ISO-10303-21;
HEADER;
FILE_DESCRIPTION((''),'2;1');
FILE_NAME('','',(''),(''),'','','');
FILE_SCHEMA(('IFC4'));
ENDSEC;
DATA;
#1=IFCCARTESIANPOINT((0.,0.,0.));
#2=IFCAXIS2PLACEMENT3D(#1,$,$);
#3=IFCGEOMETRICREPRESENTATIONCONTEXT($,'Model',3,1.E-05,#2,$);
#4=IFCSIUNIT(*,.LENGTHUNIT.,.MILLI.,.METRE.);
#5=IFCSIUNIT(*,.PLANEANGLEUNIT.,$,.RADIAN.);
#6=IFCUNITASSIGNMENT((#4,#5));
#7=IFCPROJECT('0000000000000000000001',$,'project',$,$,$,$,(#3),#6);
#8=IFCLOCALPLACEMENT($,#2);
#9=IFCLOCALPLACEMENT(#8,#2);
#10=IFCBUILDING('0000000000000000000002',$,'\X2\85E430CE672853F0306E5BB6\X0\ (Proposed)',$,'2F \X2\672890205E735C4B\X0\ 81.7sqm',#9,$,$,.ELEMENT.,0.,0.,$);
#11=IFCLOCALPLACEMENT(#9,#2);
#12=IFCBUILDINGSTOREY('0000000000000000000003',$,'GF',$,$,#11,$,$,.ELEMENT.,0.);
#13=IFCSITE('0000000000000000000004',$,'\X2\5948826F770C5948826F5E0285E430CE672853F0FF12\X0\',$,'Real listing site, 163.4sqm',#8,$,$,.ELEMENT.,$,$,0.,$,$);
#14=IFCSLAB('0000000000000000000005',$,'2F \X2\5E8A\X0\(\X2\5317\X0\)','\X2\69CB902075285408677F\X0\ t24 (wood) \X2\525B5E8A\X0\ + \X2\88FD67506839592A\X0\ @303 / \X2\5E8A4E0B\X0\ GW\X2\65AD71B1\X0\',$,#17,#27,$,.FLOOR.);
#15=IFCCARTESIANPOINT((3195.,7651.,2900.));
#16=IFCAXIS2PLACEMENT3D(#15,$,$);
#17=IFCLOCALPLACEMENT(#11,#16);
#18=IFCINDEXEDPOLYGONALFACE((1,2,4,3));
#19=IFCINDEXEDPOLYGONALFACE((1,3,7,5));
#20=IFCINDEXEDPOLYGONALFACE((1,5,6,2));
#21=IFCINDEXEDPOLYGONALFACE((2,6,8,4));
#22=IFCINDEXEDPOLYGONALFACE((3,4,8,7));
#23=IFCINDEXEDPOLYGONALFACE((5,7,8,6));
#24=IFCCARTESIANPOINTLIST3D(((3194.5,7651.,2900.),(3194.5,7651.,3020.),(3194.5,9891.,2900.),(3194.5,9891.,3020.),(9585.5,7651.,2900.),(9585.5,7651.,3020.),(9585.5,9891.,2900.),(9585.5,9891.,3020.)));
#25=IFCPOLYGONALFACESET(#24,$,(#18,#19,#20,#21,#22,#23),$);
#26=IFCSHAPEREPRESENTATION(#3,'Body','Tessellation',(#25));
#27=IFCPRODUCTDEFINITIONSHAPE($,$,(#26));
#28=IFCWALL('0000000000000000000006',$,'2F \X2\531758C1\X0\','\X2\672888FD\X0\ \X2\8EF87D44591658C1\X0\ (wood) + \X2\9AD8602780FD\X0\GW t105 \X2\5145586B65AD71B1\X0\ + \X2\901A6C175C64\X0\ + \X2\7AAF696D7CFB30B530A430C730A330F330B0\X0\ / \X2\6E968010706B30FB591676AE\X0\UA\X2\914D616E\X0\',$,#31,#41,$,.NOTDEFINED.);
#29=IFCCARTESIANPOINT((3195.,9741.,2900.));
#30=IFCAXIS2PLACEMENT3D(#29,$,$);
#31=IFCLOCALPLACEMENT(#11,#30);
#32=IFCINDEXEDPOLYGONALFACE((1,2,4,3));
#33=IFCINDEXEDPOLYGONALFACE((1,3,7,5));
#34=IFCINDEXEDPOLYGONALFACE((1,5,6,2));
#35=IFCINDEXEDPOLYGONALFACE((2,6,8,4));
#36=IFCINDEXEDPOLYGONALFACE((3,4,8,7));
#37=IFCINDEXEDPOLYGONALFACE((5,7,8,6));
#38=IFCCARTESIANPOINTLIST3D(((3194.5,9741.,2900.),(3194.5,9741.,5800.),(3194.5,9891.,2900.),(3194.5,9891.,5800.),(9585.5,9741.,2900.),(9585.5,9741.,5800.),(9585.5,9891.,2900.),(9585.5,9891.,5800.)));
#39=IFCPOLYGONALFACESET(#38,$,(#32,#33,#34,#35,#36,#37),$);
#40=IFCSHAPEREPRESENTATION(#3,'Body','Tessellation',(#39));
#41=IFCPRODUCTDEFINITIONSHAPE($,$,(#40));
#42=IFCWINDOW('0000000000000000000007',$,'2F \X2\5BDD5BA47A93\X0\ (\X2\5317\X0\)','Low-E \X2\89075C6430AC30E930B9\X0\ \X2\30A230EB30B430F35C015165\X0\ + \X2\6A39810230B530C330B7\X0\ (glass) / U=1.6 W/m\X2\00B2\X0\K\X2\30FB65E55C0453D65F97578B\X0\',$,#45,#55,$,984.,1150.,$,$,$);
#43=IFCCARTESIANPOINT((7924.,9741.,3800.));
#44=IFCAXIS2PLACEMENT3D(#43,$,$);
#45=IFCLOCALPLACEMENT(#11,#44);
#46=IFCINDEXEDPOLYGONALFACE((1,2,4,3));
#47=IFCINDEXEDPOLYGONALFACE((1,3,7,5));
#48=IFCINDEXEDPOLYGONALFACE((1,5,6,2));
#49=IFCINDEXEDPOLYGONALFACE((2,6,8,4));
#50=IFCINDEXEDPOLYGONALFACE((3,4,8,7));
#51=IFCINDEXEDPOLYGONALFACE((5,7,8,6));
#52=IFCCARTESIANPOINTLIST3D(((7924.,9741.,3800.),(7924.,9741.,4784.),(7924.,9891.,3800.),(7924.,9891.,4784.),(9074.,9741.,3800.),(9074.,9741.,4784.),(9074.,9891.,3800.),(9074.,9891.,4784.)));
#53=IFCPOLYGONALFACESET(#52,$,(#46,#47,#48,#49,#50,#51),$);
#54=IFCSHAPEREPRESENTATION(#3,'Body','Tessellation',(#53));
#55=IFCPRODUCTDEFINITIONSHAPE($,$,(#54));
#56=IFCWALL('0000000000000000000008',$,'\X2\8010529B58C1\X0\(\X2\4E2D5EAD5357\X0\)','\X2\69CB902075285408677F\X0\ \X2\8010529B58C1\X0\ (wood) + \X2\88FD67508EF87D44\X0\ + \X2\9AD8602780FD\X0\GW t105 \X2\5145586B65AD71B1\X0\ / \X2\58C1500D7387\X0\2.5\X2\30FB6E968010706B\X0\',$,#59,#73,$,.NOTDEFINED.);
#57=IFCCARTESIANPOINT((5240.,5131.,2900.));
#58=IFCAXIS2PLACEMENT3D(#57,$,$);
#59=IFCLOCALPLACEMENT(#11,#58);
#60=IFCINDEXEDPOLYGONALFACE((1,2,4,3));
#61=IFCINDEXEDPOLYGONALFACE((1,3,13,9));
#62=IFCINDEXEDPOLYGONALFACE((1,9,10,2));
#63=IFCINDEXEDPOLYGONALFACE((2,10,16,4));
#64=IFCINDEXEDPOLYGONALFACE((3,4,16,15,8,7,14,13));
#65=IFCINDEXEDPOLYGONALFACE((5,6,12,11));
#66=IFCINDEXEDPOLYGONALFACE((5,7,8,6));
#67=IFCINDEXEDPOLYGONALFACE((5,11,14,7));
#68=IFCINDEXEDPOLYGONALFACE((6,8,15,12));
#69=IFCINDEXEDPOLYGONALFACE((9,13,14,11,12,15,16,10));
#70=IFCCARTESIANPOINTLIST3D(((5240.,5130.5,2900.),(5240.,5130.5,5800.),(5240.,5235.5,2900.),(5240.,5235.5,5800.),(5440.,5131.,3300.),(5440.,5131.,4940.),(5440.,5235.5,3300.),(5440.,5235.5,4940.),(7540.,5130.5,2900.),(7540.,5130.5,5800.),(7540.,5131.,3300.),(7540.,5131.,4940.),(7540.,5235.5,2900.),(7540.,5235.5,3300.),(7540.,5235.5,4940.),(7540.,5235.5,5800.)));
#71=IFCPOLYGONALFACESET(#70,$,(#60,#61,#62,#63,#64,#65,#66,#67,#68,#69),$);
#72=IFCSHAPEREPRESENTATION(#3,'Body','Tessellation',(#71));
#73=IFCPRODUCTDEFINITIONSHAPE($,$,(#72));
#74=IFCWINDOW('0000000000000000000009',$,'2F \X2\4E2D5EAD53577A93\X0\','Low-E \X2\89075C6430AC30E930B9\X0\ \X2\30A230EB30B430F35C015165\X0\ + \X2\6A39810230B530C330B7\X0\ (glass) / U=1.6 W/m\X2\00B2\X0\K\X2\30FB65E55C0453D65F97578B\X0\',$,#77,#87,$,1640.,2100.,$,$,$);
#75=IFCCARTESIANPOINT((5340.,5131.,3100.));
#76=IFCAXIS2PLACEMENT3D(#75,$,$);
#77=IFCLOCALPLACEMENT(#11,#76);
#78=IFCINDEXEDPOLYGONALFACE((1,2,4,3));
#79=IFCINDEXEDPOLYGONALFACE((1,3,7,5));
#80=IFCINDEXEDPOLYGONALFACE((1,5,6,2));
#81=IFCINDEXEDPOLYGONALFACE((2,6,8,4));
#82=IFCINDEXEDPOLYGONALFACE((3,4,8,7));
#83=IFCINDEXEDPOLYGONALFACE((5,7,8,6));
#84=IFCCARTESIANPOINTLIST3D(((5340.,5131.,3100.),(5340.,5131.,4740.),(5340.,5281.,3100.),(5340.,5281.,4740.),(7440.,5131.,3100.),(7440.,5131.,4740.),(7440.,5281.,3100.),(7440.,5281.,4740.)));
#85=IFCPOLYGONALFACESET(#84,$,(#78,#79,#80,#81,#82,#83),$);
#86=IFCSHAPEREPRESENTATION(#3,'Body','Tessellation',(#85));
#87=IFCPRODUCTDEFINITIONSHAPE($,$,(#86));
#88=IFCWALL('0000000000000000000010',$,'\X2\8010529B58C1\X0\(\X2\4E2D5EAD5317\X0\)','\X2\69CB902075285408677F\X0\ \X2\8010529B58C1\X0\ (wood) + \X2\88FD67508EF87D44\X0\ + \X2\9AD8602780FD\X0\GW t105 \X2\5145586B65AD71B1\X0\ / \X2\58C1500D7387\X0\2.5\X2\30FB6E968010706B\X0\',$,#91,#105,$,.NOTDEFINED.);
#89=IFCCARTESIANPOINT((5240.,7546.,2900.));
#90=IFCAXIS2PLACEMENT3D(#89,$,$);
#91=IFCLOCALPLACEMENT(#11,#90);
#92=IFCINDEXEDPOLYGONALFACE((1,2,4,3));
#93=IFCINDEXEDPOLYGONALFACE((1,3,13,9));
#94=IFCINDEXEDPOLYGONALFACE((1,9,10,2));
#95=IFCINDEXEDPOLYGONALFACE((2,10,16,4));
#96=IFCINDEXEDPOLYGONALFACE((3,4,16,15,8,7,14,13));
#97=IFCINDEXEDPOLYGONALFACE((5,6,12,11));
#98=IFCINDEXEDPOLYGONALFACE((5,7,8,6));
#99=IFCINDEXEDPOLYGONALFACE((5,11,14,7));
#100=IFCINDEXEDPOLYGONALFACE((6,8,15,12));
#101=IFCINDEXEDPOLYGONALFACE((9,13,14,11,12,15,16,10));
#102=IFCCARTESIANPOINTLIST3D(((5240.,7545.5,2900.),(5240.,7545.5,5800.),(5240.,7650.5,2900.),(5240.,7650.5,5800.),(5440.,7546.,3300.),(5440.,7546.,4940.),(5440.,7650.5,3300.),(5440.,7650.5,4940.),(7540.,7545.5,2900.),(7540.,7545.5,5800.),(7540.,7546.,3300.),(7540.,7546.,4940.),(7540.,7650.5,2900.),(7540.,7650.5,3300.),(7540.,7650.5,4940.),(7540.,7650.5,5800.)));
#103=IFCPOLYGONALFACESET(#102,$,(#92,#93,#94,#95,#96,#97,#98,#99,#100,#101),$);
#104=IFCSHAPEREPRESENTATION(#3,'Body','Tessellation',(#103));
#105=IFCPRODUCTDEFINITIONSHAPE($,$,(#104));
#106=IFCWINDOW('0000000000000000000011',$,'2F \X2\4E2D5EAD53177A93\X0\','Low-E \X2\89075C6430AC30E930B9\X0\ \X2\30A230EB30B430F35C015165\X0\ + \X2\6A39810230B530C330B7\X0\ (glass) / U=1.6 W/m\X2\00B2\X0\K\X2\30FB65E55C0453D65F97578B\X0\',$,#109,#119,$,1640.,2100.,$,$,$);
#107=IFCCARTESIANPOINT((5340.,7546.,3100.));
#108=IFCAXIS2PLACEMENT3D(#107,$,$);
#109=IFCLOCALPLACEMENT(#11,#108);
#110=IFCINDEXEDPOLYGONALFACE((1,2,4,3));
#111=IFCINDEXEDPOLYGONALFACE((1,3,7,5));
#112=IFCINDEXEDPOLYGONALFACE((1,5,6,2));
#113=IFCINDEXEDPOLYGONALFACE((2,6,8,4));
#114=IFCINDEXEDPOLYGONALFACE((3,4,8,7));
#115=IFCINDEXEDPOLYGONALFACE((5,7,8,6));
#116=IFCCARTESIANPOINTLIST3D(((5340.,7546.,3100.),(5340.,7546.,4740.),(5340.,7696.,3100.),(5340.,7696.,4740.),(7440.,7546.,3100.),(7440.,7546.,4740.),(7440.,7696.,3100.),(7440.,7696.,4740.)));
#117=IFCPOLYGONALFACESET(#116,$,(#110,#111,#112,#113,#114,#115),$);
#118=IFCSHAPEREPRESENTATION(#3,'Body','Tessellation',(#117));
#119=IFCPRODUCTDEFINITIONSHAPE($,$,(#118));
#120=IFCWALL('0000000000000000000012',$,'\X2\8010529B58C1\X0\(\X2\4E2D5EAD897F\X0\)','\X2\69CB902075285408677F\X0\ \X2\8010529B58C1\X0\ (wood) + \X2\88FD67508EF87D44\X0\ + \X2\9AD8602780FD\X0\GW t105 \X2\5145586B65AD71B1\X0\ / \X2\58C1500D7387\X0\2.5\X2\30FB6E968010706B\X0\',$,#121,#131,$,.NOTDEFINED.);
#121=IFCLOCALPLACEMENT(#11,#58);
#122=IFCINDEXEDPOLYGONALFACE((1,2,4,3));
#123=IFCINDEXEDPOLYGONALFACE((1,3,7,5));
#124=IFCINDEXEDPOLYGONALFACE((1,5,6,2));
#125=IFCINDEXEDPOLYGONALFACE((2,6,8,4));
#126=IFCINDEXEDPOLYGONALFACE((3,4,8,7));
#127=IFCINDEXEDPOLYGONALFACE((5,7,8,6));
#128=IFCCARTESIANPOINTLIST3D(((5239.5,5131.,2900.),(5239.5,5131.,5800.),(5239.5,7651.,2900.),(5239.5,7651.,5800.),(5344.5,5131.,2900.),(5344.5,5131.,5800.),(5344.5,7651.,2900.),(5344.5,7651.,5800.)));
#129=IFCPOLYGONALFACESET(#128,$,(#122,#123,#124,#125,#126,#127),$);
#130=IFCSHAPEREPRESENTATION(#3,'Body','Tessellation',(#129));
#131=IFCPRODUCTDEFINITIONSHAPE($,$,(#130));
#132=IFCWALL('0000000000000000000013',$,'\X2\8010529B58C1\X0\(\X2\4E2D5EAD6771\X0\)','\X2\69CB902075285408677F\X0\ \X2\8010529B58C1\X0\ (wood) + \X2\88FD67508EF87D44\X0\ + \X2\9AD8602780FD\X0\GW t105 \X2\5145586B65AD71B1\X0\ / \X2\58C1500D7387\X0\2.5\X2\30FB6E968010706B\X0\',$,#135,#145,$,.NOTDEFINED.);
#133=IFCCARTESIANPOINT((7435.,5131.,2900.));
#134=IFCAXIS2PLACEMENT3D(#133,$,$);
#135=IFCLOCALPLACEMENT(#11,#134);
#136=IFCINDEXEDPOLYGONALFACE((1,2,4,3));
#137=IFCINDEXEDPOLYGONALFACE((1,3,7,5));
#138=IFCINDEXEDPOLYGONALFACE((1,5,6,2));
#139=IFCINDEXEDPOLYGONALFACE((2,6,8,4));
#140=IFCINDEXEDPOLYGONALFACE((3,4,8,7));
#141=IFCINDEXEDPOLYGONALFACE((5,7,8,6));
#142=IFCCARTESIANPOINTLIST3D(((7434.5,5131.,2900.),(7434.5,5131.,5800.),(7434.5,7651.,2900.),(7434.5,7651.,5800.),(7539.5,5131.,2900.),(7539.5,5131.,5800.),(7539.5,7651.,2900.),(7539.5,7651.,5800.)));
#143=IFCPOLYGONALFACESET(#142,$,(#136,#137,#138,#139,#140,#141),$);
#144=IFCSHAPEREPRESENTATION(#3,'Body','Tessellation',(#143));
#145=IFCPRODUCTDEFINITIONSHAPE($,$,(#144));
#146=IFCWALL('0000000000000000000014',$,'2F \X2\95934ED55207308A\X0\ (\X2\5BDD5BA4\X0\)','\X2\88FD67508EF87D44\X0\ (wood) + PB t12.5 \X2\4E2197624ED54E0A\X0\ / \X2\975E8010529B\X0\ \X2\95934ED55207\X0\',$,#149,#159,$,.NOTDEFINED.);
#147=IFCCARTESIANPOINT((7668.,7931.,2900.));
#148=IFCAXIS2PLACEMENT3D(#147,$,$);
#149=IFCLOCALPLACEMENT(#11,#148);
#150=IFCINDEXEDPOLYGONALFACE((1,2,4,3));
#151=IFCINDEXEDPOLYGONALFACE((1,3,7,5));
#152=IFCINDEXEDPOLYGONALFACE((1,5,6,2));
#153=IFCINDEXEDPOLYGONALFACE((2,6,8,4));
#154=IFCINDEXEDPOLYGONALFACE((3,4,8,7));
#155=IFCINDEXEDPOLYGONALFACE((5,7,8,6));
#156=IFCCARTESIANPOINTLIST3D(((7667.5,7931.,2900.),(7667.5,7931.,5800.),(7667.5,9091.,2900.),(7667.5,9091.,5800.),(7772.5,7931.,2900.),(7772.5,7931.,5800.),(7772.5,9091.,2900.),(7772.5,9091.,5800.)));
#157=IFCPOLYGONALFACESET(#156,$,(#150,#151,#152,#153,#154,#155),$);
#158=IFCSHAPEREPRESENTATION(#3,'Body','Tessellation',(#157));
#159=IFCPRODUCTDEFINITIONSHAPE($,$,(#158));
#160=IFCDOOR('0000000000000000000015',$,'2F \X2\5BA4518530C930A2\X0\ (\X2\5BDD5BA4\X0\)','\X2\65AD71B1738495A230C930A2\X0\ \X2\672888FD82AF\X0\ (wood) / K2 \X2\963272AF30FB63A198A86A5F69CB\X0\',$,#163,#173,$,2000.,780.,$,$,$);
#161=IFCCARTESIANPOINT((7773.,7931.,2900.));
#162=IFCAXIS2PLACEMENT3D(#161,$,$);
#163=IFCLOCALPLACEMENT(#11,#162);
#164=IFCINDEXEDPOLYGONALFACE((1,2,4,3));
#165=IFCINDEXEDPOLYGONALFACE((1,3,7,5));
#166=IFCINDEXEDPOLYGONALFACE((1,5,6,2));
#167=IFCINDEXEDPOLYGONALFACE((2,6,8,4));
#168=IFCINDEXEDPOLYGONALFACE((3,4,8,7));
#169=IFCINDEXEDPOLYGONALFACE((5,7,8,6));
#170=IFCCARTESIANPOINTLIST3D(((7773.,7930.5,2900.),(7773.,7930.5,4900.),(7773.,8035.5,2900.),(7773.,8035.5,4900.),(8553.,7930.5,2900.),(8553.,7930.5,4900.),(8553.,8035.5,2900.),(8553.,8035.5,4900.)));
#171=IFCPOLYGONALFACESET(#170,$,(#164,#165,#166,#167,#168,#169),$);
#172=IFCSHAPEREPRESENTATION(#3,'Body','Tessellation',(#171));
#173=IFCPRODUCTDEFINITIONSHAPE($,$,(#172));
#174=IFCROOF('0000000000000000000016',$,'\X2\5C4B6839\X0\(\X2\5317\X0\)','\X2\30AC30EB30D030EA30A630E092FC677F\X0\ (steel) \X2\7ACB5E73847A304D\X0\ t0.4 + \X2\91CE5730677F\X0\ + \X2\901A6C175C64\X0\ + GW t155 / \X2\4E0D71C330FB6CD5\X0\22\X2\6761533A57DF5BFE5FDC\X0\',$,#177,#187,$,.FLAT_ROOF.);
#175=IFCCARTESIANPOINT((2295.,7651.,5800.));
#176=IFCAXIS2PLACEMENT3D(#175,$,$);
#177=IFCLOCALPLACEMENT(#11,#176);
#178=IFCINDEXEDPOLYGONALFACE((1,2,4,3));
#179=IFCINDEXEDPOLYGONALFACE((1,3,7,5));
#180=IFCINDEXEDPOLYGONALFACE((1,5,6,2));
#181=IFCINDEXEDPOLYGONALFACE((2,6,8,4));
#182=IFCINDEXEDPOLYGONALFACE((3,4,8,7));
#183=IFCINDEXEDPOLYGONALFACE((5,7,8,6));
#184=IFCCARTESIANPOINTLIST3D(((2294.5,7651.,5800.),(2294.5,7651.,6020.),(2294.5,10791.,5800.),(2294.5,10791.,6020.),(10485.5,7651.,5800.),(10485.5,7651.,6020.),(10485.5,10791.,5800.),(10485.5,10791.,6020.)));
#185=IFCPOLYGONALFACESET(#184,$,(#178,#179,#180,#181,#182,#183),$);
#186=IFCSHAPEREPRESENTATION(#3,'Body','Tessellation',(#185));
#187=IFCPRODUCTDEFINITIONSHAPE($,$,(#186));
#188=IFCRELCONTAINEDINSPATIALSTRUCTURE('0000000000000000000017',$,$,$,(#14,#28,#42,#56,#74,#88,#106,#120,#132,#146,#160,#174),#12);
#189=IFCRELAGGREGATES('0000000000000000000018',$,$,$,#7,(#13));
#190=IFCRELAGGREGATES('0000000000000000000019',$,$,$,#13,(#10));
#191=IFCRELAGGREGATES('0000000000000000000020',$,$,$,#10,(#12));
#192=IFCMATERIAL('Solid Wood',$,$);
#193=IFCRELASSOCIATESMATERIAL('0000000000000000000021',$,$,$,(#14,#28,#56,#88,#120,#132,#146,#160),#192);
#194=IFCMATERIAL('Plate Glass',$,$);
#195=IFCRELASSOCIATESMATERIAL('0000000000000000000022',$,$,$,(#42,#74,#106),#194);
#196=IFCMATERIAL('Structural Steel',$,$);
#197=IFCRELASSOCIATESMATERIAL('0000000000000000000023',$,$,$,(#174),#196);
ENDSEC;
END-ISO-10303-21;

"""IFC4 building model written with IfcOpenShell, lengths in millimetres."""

from ifc_helpers import new_model, si_unit, frame, frame_2d, origin, place, context, project, spatial, rectangle, extrude, material, element, fill, save


model = new_model("IFC4")

# Units and contexts
model_context = context("Model", 3, precision=1e-05, world=origin())
ifc_project = project(units=[si_unit("LENGTHUNIT", "METRE", prefix="MILLI"), si_unit("PLANEANGLEUNIT", "RADIAN")], contexts=[model_context])

# Site, building, storey
site_placement = place(None, origin())
site = spatial("IfcSite", under=ifc_project, at=site_placement, Name="奈良県奈良市藤ノ木台２", ObjectType="Real listing site, 163.4sqm", CompositionType="ELEMENT", RefElevation=0.0)
building_placement = place(site_placement, origin())
building = spatial("IfcBuilding", under=site, at=building_placement, Name="藤ノ木台の家 (Proposed)", ObjectType="2F 木造平屋 81.7sqm", CompositionType="ELEMENT", ElevationOfRefHeight=0.0, ElevationOfTerrain=0.0)
storey_placement = place(building_placement, origin())
storey = spatial("IfcBuildingStorey", under=building, at=storey_placement, Name="GF", CompositionType="ELEMENT", Elevation=0.0)

# Slab
ifc_material_1 = material(Name="Solid Wood")
slab_placement = place(storey_placement, frame((3195.0, 7651.0, 2900.0)))
element("IfcSlab", 1, at=slab_placement, inside=storey, material=ifc_material_1, Name="2F 床(北)", Description="構造用合板 t24 (wood) 剛床 + 製材根太 @303 / 床下 GW断熱", PredefinedType="FLOOR", context=model_context, shape_type="SweptSolid", body=[
    extrude(rectangle(XDim=6391.0, YDim=2240.0, at=frame_2d((3195.0, 1120.0))), frame((3195.0, 7651.0, 2900.0)), (0.0, 0.0, 1.0), 120.0),
])

# Walls, openings, windows
wall_1_placement = place(storey_placement, frame((3195.0, 9741.0, 2900.0)))
wall_1 = element("IfcWall", 2, at=wall_1_placement, inside=storey, material=ifc_material_1, Name="2F 北壁", Description="木製 軸組外壁 (wood) + 高性能GW t105 充填断熱 + 通気層 + 窯業系サイディング / 準耐火・外皮UA配慮", PredefinedType="NOTDEFINED", context=model_context, shape_type="SweptSolid", body=[
    extrude(rectangle(XDim=6391.0, YDim=150.0, at=frame_2d((3195.0, 75.0))), frame((3195.0, 9741.0, 2900.0)), (0.0, 0.0, 1.0), 2900.0),
])
opening_1_placement = place(storey_placement, frame((7924.0, 9741.0, 3800.0)))
opening_1 = element("IfcOpeningElement", 3, at=opening_1_placement, cuts=wall_1, PredefinedType="NOTDEFINED", context=model_context, shape_type="SweptSolid", body=[
    extrude(rectangle(XDim=1150.0, YDim=150.0, at=frame_2d((575.0, 75.0))), frame((7924.0, 9741.0, 3800.0)), (0.0, 0.0, 1.0), 984.0),
])
ifc_material_2 = material(Name="Plate Glass")
window_1_placement = place(storey_placement, frame((7924.0, 9741.0, 3800.0)))
window_1 = element("IfcWindow", 4, at=window_1_placement, inside=storey, material=ifc_material_2, Name="2F 寝室窓 (北)", Description="Low-E 複層ガラス アルゴン封入 + 樹脂サッシ (glass) / U=1.6 W/m²K・日射取得型", OverallHeight=984.0, OverallWidth=1150.0, context=model_context, shape_type="SweptSolid", body=[
    extrude(rectangle(XDim=1150.0, YDim=150.0, at=frame_2d((575.0, 75.0))), frame((7924.0, 9741.0, 3800.0)), (0.0, 0.0, 1.0), 984.0),
])
fill(opening_1, window_1)
wall_2_placement = place(storey_placement, frame((5240.0, 5131.0, 2900.0)))
wall_2 = element("IfcWall", 5, at=wall_2_placement, inside=storey, material=ifc_material_1, Name="耐力壁(中庭南)", Description="構造用合板 耐力壁 (wood) + 製材軸組 + 高性能GW t105 充填断熱 / 壁倍率2.5・準耐火", PredefinedType="NOTDEFINED", context=model_context, shape_type="SweptSolid", body=[
    extrude(rectangle(XDim=2300.0, YDim=105.0, at=frame_2d((1150.0, 52.0))), frame((5240.0, 5131.0, 2900.0)), (0.0, 0.0, 1.0), 2900.0),
])
opening_2_placement = place(storey_placement, frame((5340.0, 5131.0, 3100.0)))
opening_2 = element("IfcOpeningElement", 6, at=opening_2_placement, cuts=wall_2, PredefinedType="NOTDEFINED", context=model_context, shape_type="SweptSolid", body=[
    extrude(rectangle(XDim=2100.0, YDim=150.0, at=frame_2d((1050.0, 75.0))), frame((5340.0, 5131.0, 3100.0)), (0.0, 0.0, 1.0), 1640.0),
])
window_2_placement = place(storey_placement, frame((5340.0, 5131.0, 3100.0)))
window_2 = element("IfcWindow", 7, at=window_2_placement, inside=storey, material=ifc_material_2, Name="2F 中庭南窓", Description="Low-E 複層ガラス アルゴン封入 + 樹脂サッシ (glass) / U=1.6 W/m²K・日射取得型", OverallHeight=1640.0, OverallWidth=2100.0, context=model_context, shape_type="SweptSolid", body=[
    extrude(rectangle(XDim=2100.0, YDim=150.0, at=frame_2d((1050.0, 75.0))), frame((5340.0, 5131.0, 3100.0)), (0.0, 0.0, 1.0), 1640.0),
])
fill(opening_2, window_2)
wall_3_placement = place(storey_placement, frame((5240.0, 7546.0, 2900.0)))
wall_3 = element("IfcWall", 8, at=wall_3_placement, inside=storey, material=ifc_material_1, Name="耐力壁(中庭北)", Description="構造用合板 耐力壁 (wood) + 製材軸組 + 高性能GW t105 充填断熱 / 壁倍率2.5・準耐火", PredefinedType="NOTDEFINED", context=model_context, shape_type="SweptSolid", body=[
    extrude(rectangle(XDim=2300.0, YDim=105.0, at=frame_2d((1150.0, 52.0))), frame((5240.0, 7546.0, 2900.0)), (0.0, 0.0, 1.0), 2900.0),
])
opening_3_placement = place(storey_placement, frame((5340.0, 7546.0, 3100.0)))
opening_3 = element("IfcOpeningElement", 9, at=opening_3_placement, cuts=wall_3, PredefinedType="NOTDEFINED", context=model_context, shape_type="SweptSolid", body=[
    extrude(rectangle(XDim=2100.0, YDim=150.0, at=frame_2d((1050.0, 75.0))), frame((5340.0, 7546.0, 3100.0)), (0.0, 0.0, 1.0), 1640.0),
])
window_3_placement = place(storey_placement, frame((5340.0, 7546.0, 3100.0)))
window_3 = element("IfcWindow", 10, at=window_3_placement, inside=storey, material=ifc_material_2, Name="2F 中庭北窓", Description="Low-E 複層ガラス アルゴン封入 + 樹脂サッシ (glass) / U=1.6 W/m²K・日射取得型", OverallHeight=1640.0, OverallWidth=2100.0, context=model_context, shape_type="SweptSolid", body=[
    extrude(rectangle(XDim=2100.0, YDim=150.0, at=frame_2d((1050.0, 75.0))), frame((5340.0, 7546.0, 3100.0)), (0.0, 0.0, 1.0), 1640.0),
])
fill(opening_3, window_3)

# Walls
wall_4_placement = place(storey_placement, frame((5240.0, 5131.0, 2900.0)))
element("IfcWall", 11, at=wall_4_placement, inside=storey, material=ifc_material_1, Name="耐力壁(中庭西)", Description="構造用合板 耐力壁 (wood) + 製材軸組 + 高性能GW t105 充填断熱 / 壁倍率2.5・準耐火", PredefinedType="NOTDEFINED", context=model_context, shape_type="SweptSolid", body=[
    extrude(rectangle(XDim=105.0, YDim=2520.0, at=frame_2d((52.0, 1260.0))), frame((5240.0, 5131.0, 2900.0)), (0.0, 0.0, 1.0), 2900.0),
])
wall_5_placement = place(storey_placement, frame((7435.0, 5131.0, 2900.0)))
element("IfcWall", 12, at=wall_5_placement, inside=storey, material=ifc_material_1, Name="耐力壁(中庭東)", Description="構造用合板 耐力壁 (wood) + 製材軸組 + 高性能GW t105 充填断熱 / 壁倍率2.5・準耐火", PredefinedType="NOTDEFINED", context=model_context, shape_type="SweptSolid", body=[
    extrude(rectangle(XDim=105.0, YDim=2520.0, at=frame_2d((52.0, 1260.0))), frame((7435.0, 5131.0, 2900.0)), (0.0, 0.0, 1.0), 2900.0),
])
wall_6_placement = place(storey_placement, frame((7668.0, 7931.0, 2900.0)))
element("IfcWall", 13, at=wall_6_placement, inside=storey, material=ifc_material_1, Name="2F 間仕切り (寝室)", Description="製材軸組 (wood) + PB t12.5 両面仕上 / 非耐力 間仕切", PredefinedType="NOTDEFINED", context=model_context, shape_type="SweptSolid", body=[
    extrude(rectangle(XDim=105.0, YDim=1160.0, at=frame_2d((52.0, 580.0))), frame((7668.0, 7931.0, 2900.0)), (0.0, 0.0, 1.0), 2900.0),
])

# Door
door_placement = place(storey_placement, frame((7773.0, 7931.0, 2900.0)))
element("IfcDoor", 14, at=door_placement, inside=storey, material=ifc_material_1, Name="2F 室内ドア (寝室)", Description="断熱玄関ドア 木製芯 (wood) / K2 防犯・採風機構", OverallHeight=2000.0, OverallWidth=780.0, context=model_context, shape_type="SweptSolid", body=[
    extrude(rectangle(XDim=780.0, YDim=105.0, at=frame_2d((390.0, 52.0))), frame((7773.0, 7931.0, 2900.0)), (0.0, 0.0, 1.0), 2000.0),
])

# Roof
ifc_material_3 = material(Name="Structural Steel")
for number, where, name in (
    (15, (2295.0, 7651.0, 5800.0), "屋根(北)"),
):
    element("IfcRoof", number, at=place(storey_placement, frame(where)), inside=storey, material=ifc_material_3, Name=name, Description="ガルバリウム鋼板 (steel) 立平葺き t0.4 + 野地板 + 通気層 + GW t155 / 不燃・法22条区域対応", PredefinedType="FLAT_ROOF", context=model_context, shape_type="SweptSolid", body=[
        extrude(rectangle(XDim=8191.0, YDim=3140.0, at=frame_2d((4095.0, 1570.0))), frame((2295.0, 7651.0, 5800.0)), (0.0, 0.0, 1.0), 220.0),
    ])

save(model, "model.ifc")
